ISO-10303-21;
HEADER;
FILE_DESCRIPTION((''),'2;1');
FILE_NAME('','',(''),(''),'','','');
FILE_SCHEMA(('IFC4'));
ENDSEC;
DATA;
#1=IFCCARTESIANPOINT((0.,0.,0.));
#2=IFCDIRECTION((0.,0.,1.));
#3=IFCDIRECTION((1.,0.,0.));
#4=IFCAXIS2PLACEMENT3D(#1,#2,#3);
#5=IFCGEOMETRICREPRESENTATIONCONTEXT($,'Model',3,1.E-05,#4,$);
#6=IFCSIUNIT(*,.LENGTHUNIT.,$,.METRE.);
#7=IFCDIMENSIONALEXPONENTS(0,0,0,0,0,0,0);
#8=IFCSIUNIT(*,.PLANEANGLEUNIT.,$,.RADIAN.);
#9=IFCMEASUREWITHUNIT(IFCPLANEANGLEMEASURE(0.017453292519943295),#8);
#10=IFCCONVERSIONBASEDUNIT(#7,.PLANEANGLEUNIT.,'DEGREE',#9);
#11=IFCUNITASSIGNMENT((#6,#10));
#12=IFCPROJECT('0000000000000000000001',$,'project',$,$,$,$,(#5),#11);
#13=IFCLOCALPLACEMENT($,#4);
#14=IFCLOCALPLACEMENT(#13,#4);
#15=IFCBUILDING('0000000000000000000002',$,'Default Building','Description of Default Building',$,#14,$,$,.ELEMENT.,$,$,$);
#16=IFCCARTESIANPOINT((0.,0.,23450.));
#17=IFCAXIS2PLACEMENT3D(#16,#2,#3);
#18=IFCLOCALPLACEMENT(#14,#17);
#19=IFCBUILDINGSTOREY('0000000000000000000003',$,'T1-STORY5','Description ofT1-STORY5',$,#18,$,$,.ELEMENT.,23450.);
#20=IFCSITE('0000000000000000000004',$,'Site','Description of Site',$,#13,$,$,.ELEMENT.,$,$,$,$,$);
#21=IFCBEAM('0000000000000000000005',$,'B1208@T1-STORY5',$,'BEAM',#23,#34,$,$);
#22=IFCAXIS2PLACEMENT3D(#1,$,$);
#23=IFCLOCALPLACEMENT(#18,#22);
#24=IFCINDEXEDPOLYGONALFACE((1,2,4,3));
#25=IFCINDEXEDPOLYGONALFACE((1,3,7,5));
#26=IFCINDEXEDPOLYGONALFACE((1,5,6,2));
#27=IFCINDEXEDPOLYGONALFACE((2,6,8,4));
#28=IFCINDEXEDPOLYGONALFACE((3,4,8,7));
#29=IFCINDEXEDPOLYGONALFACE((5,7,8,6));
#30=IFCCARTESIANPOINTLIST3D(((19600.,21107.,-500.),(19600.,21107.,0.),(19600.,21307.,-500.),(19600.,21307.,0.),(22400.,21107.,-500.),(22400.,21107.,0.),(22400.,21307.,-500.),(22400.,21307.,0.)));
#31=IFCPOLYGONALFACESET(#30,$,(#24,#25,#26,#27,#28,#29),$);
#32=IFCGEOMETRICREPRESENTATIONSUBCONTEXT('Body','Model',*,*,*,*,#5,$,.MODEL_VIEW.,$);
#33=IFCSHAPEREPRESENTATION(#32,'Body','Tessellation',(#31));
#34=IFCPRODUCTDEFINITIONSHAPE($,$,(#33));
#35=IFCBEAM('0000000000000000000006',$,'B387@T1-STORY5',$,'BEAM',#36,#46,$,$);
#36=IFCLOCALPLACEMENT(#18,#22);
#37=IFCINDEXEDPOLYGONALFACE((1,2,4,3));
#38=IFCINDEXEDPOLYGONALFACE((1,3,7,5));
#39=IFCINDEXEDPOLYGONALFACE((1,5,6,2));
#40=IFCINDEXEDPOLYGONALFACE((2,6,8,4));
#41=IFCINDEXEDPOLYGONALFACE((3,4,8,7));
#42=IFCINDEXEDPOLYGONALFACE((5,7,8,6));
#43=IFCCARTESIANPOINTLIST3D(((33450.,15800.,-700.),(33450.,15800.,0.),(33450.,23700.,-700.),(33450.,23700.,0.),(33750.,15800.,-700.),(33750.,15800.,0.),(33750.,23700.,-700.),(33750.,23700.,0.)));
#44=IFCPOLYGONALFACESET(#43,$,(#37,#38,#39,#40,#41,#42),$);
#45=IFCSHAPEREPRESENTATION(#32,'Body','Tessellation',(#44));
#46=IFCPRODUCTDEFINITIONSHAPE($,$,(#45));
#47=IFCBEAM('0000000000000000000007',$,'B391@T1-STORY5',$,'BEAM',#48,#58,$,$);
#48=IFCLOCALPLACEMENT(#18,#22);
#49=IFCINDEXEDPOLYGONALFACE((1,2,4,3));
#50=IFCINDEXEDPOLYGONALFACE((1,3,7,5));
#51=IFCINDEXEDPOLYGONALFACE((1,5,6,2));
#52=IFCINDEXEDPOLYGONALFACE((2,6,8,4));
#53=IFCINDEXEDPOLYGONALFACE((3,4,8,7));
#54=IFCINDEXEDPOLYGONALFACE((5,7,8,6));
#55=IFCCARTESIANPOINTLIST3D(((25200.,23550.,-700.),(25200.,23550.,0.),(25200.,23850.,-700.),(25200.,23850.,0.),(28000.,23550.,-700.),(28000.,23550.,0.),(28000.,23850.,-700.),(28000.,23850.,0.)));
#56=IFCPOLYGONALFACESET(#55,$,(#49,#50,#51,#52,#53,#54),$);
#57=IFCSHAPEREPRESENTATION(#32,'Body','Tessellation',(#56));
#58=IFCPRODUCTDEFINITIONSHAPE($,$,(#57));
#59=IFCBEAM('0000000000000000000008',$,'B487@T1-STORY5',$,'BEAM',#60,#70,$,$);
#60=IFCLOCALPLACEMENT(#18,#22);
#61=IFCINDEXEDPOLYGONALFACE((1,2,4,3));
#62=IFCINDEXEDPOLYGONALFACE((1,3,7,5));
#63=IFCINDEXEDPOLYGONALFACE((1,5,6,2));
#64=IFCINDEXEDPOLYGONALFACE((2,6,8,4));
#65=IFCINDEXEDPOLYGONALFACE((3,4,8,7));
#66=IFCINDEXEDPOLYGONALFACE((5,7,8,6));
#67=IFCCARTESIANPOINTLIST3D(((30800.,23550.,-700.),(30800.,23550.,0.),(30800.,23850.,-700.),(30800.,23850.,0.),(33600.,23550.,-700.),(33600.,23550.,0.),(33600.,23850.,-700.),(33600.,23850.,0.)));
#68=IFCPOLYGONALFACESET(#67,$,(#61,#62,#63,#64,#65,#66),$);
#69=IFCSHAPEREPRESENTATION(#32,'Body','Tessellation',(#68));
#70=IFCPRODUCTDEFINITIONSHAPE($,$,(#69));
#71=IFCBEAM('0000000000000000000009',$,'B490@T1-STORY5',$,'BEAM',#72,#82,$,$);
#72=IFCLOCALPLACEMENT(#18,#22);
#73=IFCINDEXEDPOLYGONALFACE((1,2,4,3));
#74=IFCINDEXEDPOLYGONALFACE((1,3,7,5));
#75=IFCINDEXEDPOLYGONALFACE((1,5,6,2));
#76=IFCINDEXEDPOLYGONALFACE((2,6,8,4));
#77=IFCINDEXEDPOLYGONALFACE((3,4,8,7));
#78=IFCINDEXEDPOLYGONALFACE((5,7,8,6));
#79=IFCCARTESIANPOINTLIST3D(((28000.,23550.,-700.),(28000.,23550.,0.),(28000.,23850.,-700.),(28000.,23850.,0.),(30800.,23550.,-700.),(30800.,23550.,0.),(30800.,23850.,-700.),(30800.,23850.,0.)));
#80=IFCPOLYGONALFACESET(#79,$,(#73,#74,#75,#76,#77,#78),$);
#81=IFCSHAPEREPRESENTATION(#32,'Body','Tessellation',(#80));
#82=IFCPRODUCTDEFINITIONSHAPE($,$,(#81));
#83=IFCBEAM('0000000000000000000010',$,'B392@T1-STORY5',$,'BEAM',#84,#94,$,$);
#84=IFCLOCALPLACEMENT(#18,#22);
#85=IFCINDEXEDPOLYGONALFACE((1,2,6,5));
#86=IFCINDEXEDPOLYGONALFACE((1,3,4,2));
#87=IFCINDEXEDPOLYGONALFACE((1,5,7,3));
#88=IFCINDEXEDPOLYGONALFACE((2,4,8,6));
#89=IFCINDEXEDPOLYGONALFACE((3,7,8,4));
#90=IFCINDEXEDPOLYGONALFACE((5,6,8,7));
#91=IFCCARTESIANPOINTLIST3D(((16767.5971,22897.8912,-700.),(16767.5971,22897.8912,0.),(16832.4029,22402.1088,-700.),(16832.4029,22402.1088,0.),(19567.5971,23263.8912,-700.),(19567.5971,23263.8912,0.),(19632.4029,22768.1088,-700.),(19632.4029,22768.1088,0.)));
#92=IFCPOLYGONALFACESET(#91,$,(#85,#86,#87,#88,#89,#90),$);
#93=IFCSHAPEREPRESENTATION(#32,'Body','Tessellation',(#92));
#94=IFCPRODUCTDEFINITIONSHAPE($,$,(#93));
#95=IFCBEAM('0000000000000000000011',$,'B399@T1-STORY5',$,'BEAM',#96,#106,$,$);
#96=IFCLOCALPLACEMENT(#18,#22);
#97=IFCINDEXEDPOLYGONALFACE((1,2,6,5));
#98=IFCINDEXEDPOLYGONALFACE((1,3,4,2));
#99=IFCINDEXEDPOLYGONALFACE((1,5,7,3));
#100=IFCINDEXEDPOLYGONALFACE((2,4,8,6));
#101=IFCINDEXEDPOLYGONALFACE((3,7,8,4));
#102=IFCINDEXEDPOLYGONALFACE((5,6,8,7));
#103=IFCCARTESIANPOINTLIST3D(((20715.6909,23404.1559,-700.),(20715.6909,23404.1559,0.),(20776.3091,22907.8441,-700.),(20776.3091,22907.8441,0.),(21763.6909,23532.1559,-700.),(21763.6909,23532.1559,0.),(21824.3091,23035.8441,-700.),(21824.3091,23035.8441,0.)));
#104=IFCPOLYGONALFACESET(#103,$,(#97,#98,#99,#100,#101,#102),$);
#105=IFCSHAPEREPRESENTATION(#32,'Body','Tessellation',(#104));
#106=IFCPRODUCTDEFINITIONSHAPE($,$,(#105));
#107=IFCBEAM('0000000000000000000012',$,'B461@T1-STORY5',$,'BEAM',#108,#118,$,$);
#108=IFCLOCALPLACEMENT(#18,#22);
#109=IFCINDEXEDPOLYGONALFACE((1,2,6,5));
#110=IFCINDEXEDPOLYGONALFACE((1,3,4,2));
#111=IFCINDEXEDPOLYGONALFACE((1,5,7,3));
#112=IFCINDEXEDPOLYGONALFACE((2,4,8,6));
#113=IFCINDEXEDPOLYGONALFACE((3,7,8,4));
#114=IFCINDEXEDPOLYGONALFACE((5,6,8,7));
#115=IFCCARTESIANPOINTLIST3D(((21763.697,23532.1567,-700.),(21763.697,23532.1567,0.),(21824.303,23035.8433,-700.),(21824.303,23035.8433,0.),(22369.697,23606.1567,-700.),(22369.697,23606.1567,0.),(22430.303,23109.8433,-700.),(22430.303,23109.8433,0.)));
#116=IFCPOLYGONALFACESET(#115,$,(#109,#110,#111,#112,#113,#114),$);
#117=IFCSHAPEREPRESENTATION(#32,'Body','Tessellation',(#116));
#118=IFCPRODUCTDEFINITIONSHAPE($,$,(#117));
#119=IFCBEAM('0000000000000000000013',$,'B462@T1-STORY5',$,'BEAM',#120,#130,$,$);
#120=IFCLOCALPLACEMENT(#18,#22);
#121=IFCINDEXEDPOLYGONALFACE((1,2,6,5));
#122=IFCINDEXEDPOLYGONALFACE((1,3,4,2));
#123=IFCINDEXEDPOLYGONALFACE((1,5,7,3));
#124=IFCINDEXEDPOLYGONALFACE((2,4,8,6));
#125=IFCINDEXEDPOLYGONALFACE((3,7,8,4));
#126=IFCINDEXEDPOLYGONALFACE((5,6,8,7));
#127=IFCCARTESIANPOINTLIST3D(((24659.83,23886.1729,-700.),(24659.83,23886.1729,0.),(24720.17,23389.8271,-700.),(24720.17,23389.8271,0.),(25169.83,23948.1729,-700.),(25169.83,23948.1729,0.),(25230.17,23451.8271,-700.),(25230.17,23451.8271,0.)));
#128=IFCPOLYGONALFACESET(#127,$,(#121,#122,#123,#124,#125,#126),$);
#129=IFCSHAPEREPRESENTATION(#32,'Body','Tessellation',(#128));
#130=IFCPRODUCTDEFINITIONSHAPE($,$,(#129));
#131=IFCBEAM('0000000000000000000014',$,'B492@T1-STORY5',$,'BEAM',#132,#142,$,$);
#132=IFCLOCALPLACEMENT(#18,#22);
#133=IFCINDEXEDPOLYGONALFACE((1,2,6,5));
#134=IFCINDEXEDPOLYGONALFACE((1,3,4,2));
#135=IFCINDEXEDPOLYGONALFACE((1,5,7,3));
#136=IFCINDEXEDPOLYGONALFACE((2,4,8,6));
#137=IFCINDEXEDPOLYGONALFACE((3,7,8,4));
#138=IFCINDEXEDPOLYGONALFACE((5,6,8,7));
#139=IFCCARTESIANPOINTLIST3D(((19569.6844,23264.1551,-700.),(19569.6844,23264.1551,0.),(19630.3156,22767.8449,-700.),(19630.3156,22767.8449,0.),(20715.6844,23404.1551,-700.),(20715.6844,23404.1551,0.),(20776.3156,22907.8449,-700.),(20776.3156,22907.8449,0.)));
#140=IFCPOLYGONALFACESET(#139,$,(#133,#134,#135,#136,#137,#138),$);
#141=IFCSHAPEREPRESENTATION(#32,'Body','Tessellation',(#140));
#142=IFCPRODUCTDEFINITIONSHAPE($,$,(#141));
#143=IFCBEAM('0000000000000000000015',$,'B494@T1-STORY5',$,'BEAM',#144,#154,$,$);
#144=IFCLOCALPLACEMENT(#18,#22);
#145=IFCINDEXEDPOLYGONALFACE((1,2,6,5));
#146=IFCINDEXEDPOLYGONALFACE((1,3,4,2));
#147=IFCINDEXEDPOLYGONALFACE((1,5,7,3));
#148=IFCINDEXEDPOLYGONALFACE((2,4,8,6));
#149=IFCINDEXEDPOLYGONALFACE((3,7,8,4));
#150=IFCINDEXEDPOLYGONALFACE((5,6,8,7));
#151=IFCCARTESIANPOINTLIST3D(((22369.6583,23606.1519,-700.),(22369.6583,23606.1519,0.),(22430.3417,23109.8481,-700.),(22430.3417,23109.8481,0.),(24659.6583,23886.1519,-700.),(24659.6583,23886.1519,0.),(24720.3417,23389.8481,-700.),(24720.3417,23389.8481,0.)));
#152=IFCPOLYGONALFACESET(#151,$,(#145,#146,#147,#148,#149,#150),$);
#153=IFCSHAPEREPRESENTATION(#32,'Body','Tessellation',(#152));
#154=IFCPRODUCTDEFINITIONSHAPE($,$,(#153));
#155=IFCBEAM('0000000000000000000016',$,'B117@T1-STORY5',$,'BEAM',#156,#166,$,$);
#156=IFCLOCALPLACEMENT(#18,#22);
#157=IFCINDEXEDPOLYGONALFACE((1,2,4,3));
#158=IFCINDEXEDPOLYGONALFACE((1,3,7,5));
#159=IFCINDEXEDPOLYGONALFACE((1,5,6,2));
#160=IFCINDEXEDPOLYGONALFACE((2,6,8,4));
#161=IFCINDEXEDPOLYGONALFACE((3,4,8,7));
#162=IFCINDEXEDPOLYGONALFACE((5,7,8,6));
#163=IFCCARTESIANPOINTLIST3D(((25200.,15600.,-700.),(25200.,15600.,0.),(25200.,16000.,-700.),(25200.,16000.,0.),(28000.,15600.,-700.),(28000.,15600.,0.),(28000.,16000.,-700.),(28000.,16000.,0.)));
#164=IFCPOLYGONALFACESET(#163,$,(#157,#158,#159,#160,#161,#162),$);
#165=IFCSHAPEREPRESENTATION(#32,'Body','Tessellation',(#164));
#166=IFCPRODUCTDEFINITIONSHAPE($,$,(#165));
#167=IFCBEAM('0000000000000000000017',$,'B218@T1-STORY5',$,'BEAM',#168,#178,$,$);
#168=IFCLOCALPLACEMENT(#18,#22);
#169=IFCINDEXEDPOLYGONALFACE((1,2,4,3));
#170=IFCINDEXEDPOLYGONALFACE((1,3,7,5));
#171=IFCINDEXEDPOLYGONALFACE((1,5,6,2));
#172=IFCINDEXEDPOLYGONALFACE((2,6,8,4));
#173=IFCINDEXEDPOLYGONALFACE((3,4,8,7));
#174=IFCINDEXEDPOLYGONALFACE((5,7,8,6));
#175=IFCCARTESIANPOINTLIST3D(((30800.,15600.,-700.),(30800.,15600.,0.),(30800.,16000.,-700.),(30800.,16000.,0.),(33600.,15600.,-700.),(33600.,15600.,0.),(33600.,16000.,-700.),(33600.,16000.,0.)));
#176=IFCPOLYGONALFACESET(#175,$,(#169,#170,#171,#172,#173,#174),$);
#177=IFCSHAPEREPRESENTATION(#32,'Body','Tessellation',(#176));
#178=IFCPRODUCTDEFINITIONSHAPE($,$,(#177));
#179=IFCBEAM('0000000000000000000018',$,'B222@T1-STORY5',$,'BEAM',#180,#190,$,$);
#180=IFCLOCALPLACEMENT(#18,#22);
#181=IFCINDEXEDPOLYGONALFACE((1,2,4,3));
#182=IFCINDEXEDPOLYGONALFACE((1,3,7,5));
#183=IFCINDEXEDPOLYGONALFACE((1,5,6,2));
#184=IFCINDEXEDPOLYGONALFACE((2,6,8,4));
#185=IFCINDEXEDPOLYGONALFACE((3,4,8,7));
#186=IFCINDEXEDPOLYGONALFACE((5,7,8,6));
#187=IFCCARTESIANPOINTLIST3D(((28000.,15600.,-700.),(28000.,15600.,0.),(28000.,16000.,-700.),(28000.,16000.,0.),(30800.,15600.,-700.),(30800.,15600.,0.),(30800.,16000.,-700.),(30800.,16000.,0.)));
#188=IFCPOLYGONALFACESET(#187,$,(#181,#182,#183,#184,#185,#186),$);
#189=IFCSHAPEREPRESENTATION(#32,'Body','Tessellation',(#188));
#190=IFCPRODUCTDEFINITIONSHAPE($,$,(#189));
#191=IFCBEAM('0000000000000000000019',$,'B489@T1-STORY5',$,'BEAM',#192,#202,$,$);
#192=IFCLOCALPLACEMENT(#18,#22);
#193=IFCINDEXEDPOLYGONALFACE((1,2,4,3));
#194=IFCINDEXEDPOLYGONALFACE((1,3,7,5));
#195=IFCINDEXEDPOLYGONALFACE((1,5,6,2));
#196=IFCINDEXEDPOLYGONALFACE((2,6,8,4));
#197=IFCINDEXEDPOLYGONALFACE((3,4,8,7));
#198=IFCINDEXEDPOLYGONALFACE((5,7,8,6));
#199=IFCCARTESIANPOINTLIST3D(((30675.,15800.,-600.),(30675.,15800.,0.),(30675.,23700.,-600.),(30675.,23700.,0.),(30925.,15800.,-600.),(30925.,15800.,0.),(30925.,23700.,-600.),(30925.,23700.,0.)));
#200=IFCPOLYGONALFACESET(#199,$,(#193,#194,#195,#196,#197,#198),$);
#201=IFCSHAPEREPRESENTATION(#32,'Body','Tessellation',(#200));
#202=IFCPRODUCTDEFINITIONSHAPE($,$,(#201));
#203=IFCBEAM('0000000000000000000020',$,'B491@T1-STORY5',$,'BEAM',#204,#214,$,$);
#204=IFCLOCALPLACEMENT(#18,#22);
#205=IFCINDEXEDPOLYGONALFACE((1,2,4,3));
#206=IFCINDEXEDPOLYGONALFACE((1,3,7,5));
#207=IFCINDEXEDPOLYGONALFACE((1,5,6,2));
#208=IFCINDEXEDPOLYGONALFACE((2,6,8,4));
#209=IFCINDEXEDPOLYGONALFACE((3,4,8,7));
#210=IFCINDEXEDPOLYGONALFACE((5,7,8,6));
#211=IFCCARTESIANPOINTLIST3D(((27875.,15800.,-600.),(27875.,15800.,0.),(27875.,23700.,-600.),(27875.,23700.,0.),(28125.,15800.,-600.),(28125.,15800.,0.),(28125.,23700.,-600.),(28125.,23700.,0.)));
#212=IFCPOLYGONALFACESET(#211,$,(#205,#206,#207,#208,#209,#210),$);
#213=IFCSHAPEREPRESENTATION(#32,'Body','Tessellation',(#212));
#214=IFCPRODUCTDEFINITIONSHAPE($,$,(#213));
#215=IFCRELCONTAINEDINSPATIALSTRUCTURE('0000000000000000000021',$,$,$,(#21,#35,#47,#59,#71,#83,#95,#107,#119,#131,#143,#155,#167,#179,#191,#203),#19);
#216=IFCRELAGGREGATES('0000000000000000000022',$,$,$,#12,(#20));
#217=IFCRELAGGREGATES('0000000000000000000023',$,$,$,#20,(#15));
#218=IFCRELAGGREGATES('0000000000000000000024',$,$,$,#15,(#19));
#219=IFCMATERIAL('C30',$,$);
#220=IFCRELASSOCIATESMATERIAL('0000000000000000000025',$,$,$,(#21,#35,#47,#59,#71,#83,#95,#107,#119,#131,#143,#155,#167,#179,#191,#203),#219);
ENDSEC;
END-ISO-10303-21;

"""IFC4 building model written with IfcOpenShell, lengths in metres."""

from ifc_helpers import new_model, entity, si_unit, converted_unit, frame, origin_with_axes, place, context, subcontext, project, spatial, rectangle, extrude, material, element, save


model = new_model("IFC4")

# Units and contexts
model_context = context("Model", 3, precision=1e-05, world=origin_with_axes())
body_context = subcontext(model_context, "Body", "Model", "MODEL_VIEW")
ifc_project = project(units=[si_unit("LENGTHUNIT", "METRE"), converted_unit("PLANEANGLEUNIT", "DEGREE", entity("IfcPlaneAngleMeasure", 0.017453292519943295), si_unit("PLANEANGLEUNIT", "RADIAN"), dimensions=[0, 0, 0, 0, 0, 0, 0])], contexts=[model_context])

# Site, building, storey
site_placement = place(None, origin_with_axes())
site = spatial("IfcSite", under=ifc_project, at=site_placement, Name="Site", Description="Description of Site", CompositionType="ELEMENT")
building_placement = place(site_placement, origin_with_axes())
building = spatial("IfcBuilding", under=site, at=building_placement, Name="Default Building", Description="Description of Default Building", CompositionType="ELEMENT")
storey_placement = place(building_placement, frame((0.0, 0.0, 23450.0), z_axis=(0.0, 0.0, 1.0), x_axis=(1.0, 0.0, 0.0)))
storey = spatial("IfcBuildingStorey", under=building, at=storey_placement, Name="T1-STORY5", Description="Description ofT1-STORY5", CompositionType="ELEMENT", Elevation=23450.0)

# Beams
ifc_material_1 = material(Name="C30")
beam_1_placement = place(storey_placement, frame((19600.0, 21207.0, -250.0), z_axis=(1.0, 0.0, 0.0), x_axis=(0.0, 1.0, 0.0)))
element("IfcBeam", 1, at=beam_1_placement, inside=storey, material=ifc_material_1, Name="B1208@T1-STORY5", ObjectType="BEAM", context=body_context, shape_type="SweptSolid", body=[
    extrude(rectangle(XDim=200.0, YDim=500.0), origin_with_axes(), (0.0, 0.0, 1.0), 2800.0),
])
beam_2_placement = place(storey_placement, frame((33600.0, 15800.0, -350.0), z_axis=(0.0, 1.0, 0.0), x_axis=(-1.0, 0.0, 0.0)))
element("IfcBeam", 2, at=beam_2_placement, inside=storey, material=ifc_material_1, Name="B387@T1-STORY5", ObjectType="BEAM", context=body_context, shape_type="SweptSolid", body=[
    extrude(rectangle(XDim=300.0, YDim=700.0), origin_with_axes(), (0.0, 0.0, 1.0), 7900.0),
])
for number, where, z_axis, x_axis, name in (
    (3, (25200.0, 23700.0, -350.0), (1.0, 0.0, 0.0), (0.0, 1.0, 0.0), "B391@T1-STORY5"),
    (4, (30800.0, 23700.0, -350.0), (1.0, 0.0, 0.0), (0.0, 1.0, 0.0), "B487@T1-STORY5"),
    (5, (28000.0, 23700.0, -350.0), (1.0, 0.0, 0.0), (0.0, 1.0, 0.0), "B490@T1-STORY5"),
):
    element("IfcBeam", number, at=place(storey_placement, frame(where, z_axis=z_axis, x_axis=x_axis)), inside=storey, material=ifc_material_1, Name=name, ObjectType="BEAM", context=body_context, shape_type="SweptSolid", body=[
        extrude(rectangle(XDim=300.0, YDim=700.0), origin_with_axes(), (0.0, 0.0, 1.0), 2800.0),
    ])
beam_3_placement = place(storey_placement, frame((16800.0, 22650.0, -350.0), z_axis=(0.991565, 0.129612, 0.0), x_axis=(-0.129612, 0.991565, 0.0)))
element("IfcBeam", 6, at=beam_3_placement, inside=storey, material=ifc_material_1, Name="B392@T1-STORY5", ObjectType="BEAM", context=body_context, shape_type="SweptSolid", body=[
    extrude(rectangle(XDim=500.0, YDim=700.0), origin_with_axes(), (0.0, 0.0, 1.0), 2823.8194),
])
beam_4_placement = place(storey_placement, frame((20746.0, 23156.0, -350.0), z_axis=(0.992624, 0.121236, 0.0), x_axis=(-0.121236, 0.992624, 0.0)))
element("IfcBeam", 7, at=beam_4_placement, inside=storey, material=ifc_material_1, Name="B399@T1-STORY5", ObjectType="BEAM", context=body_context, shape_type="SweptSolid", body=[
    extrude(rectangle(XDim=500.0, YDim=700.0), origin_with_axes(), (0.0, 0.0, 1.0), 1055.7879),
])
beam_5_placement = place(storey_placement, frame((21794.0, 23284.0, -350.0), z_axis=(0.992627, 0.121212, 0.0), x_axis=(-0.121212, 0.992627, 0.0)))
element("IfcBeam", 8, at=beam_5_placement, inside=storey, material=ifc_material_1, Name="B461@T1-STORY5", ObjectType="BEAM", context=body_context, shape_type="SweptSolid", body=[
    extrude(rectangle(XDim=500.0, YDim=700.0), origin_with_axes(), (0.0, 0.0, 1.0), 610.5014),
])
beam_6_placement = place(storey_placement, frame((24690.0, 23638.0, -350.0), z_axis=(0.992691, 0.12068, 0.0), x_axis=(-0.12068, 0.992691, 0.0)))
element("IfcBeam", 9, at=beam_6_placement, inside=storey, material=ifc_material_1, Name="B462@T1-STORY5", ObjectType="BEAM", context=body_context, shape_type="SweptSolid", body=[
    extrude(rectangle(XDim=500.0, YDim=700.0), origin_with_axes(), (0.0, 0.0, 1.0), 513.7548),
])
beam_7_placement = place(storey_placement, frame((19600.0, 23016.0, -350.0), z_axis=(0.99262, 0.121263, 0.0), x_axis=(-0.121263, 0.99262, 0.0)))
element("IfcBeam", 10, at=beam_7_placement, inside=storey, material=ifc_material_1, Name="B492@T1-STORY5", ObjectType="BEAM", context=body_context, shape_type="SweptSolid", body=[
    extrude(rectangle(XDim=500.0, YDim=700.0), origin_with_axes(), (0.0, 0.0, 1.0), 1154.5198),
])
beam_8_placement = place(storey_placement, frame((22400.0, 23358.0, -350.0), z_axis=(0.992608, 0.121367, 0.0), x_axis=(-0.121367, 0.992608, 0.0)))
element("IfcBeam", 11, at=beam_8_placement, inside=storey, material=ifc_material_1, Name="B494@T1-STORY5", ObjectType="BEAM", context=body_context, shape_type="SweptSolid", body=[
    extrude(rectangle(XDim=500.0, YDim=700.0), origin_with_axes(), (0.0, 0.0, 1.0), 2307.0544),
])
for number, where, z_axis, x_axis, name in (
    (12, (25200.0, 15800.0, -350.0), (1.0, 0.0, 0.0), (0.0, 1.0, 0.0), "B117@T1-STORY5"),
    (13, (30800.0, 15800.0, -350.0), (1.0, 0.0, 0.0), (0.0, 1.0, 0.0), "B218@T1-STORY5"),
    (14, (28000.0, 15800.0, -350.0), (1.0, 0.0, 0.0), (0.0, 1.0, 0.0), "B222@T1-STORY5"),
):
    element("IfcBeam", number, at=place(storey_placement, frame(where, z_axis=z_axis, x_axis=x_axis)), inside=storey, material=ifc_material_1, Name=name, ObjectType="BEAM", context=body_context, shape_type="SweptSolid", body=[
        extrude(rectangle(XDim=400.0, YDim=700.0), origin_with_axes(), (0.0, 0.0, 1.0), 2800.0),
    ])
for number, where, z_axis, x_axis, name in (
    (15, (30800.0, 15800.0, -300.0), (0.0, 1.0, 0.0), (-1.0, 0.0, 0.0), "B489@T1-STORY5"),
    (16, (28000.0, 15800.0, -300.0), (0.0, 1.0, 0.0), (-1.0, 0.0, 0.0), "B491@T1-STORY5"),
):
    element("IfcBeam", number, at=place(storey_placement, frame(where, z_axis=z_axis, x_axis=x_axis)), inside=storey, material=ifc_material_1, Name=name, ObjectType="BEAM", context=body_context, shape_type="SweptSolid", body=[
        extrude(rectangle(XDim=250.0, YDim=600.0), origin_with_axes(), (0.0, 0.0, 1.0), 7900.0),
    ])

save(model, "model.ifc")
